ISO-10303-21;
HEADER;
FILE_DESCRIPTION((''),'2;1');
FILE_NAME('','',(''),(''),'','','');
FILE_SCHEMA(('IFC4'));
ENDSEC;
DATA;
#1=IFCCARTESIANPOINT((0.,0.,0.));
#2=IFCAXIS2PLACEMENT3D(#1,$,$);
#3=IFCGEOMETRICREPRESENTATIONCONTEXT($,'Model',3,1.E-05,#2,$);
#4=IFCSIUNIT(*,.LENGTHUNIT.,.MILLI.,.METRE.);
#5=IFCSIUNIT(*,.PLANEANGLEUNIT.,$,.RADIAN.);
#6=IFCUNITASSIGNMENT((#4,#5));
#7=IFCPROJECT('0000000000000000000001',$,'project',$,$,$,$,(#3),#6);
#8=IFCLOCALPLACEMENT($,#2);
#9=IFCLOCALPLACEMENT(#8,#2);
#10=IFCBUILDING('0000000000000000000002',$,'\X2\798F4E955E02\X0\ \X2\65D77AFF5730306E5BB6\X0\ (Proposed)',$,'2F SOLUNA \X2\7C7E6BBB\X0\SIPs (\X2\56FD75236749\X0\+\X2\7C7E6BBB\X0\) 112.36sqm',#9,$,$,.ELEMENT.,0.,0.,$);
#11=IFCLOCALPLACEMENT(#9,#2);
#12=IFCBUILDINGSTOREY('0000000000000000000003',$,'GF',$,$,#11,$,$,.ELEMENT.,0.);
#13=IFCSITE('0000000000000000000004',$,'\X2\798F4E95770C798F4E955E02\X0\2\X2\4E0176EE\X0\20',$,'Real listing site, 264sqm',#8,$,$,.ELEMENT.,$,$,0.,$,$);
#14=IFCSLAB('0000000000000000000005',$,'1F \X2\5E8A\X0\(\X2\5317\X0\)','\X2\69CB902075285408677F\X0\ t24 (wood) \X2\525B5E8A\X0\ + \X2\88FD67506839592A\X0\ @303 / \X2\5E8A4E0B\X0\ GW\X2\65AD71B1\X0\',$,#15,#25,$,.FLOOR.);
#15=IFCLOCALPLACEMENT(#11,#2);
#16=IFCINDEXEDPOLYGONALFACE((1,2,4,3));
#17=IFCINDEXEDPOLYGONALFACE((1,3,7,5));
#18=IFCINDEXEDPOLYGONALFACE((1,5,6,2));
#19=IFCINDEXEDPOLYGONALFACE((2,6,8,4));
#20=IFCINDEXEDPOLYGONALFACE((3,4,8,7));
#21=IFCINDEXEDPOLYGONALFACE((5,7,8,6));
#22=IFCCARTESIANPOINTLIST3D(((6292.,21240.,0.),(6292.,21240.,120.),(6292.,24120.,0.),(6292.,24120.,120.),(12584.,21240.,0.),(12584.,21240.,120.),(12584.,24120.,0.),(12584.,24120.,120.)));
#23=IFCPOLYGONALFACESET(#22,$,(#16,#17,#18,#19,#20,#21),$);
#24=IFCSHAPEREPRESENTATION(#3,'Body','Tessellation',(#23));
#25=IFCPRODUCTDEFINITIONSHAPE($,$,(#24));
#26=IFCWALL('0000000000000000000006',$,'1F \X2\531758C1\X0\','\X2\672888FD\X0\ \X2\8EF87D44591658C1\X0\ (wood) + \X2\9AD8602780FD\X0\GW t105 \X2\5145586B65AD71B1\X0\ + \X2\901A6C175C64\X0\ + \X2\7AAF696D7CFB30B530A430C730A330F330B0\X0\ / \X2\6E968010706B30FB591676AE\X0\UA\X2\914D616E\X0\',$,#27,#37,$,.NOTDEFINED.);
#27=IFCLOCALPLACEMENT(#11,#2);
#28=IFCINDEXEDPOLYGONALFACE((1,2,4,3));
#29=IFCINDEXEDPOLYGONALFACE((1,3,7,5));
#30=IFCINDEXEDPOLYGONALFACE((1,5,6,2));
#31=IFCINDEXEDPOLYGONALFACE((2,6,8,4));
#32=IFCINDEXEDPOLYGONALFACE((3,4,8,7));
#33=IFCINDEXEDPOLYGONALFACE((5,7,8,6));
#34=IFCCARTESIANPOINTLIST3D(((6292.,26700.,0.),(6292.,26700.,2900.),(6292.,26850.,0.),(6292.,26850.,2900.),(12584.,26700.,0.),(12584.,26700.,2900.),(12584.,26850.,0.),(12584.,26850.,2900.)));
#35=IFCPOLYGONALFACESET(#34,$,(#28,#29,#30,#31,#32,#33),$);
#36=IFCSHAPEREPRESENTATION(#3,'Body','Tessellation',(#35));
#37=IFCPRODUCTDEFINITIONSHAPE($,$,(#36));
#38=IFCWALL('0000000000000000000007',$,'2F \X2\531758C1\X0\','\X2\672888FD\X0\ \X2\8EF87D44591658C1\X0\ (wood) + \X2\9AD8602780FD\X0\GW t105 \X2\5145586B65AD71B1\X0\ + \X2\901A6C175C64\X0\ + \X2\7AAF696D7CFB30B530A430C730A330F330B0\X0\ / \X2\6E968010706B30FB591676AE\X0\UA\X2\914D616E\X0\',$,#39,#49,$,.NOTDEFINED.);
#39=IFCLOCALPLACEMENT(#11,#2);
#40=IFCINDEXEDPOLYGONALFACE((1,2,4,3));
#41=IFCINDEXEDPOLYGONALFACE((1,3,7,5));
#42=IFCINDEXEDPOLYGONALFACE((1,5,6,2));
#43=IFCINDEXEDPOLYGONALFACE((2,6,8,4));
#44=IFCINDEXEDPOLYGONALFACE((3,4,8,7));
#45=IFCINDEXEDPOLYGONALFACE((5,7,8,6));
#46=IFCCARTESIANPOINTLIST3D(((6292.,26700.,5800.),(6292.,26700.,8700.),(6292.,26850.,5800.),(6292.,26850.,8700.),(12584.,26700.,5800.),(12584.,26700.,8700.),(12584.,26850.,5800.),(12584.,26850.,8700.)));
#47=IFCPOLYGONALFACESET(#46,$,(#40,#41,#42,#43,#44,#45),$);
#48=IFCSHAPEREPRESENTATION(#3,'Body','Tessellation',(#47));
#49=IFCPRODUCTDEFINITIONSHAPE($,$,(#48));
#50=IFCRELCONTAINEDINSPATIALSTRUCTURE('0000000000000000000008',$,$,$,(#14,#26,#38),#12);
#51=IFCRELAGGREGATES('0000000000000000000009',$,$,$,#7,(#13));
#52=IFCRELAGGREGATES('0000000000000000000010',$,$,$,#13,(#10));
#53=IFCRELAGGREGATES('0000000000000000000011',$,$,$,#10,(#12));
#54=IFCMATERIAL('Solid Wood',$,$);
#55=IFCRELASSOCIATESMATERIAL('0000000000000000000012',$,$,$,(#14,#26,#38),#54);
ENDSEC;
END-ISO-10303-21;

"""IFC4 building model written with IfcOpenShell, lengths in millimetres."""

from ifc_helpers import new_model, si_unit, frame, frame_2d, origin, place, context, project, spatial, rectangle, extrude, material, element, save


model = new_model("IFC4")

# Units and contexts
model_context = context("Model", 3, precision=1e-05, world=origin())
ifc_project = project(units=[si_unit("LENGTHUNIT", "METRE", prefix="MILLI"), si_unit("PLANEANGLEUNIT", "RADIAN")], contexts=[model_context])

# Site, building, storey
site_placement = place(None, origin())
site = spatial("IfcSite", under=ifc_project, at=site_placement, Name="福井県福井市2丁目20", ObjectType="Real listing site, 264sqm", CompositionType="ELEMENT", RefElevation=0.0)
building_placement = place(site_placement, origin())
building = spatial("IfcBuilding", under=site, at=building_placement, Name="福井市 旗竿地の家 (Proposed)", ObjectType="2F SOLUNA 籾殻SIPs (国産杉+籾殻) 112.36sqm", CompositionType="ELEMENT", ElevationOfRefHeight=0.0, ElevationOfTerrain=0.0)
storey_placement = place(building_placement, origin())
storey = spatial("IfcBuildingStorey", under=building, at=storey_placement, Name="GF", CompositionType="ELEMENT", Elevation=0.0)

# Slab
ifc_material_1 = material(Name="Solid Wood")
slab_1_placement = place(storey_placement, frame((3146.0, 10620.0, 0.0)))
element("IfcSlab", 1, at=slab_1_placement, inside=storey, material=ifc_material_1, Name="1F 床(北)", Description="構造用合板 t24 (wood) 剛床 + 製材根太 @303 / 床下 GW断熱", PredefinedType="FLOOR", context=model_context, shape_type="SweptSolid", body=[
    extrude(rectangle(XDim=6292.0, YDim=2880.0, at=frame_2d((3146.0, 1440.0))), frame((3146.0, 10620.0, 0.0)), (0.0, 0.0, 1.0), 120.0),
])

# Wall
wall_1_placement = place(storey_placement, frame((3146.0, 13350.0, 0.0)))
element("IfcWall", 2, at=wall_1_placement, inside=storey, material=ifc_material_1, Name="1F 北壁", Description="木製 軸組外壁 (wood) + 高性能GW t105 充填断熱 + 通気層 + 窯業系サイディング / 準耐火・外皮UA配慮", PredefinedType="NOTDEFINED", context=model_context, shape_type="SweptSolid", body=[
    extrude(rectangle(XDim=6292.0, YDim=150.0, at=frame_2d((3146.0, 75.0))), frame((3146.0, 13350.0, 0.0)), (0.0, 0.0, 1.0), 2900.0),
])

# Wall
wall_2_placement = place(storey_placement, frame((3146.0, 13350.0, 2900.0)))
element("IfcWall", 3, at=wall_2_placement, inside=storey, material=ifc_material_1, Name="2F 北壁", Description="木製 軸組外壁 (wood) + 高性能GW t105 充填断熱 + 通気層 + 窯業系サイディング / 準耐火・外皮UA配慮", PredefinedType="NOTDEFINED", context=model_context, shape_type="SweptSolid", body=[
    extrude(rectangle(XDim=6292.0, YDim=150.0, at=frame_2d((3146.0, 75.0))), frame((3146.0, 13350.0, 2900.0)), (0.0, 0.0, 1.0), 2900.0),
])

save(model, "model.ifc")
